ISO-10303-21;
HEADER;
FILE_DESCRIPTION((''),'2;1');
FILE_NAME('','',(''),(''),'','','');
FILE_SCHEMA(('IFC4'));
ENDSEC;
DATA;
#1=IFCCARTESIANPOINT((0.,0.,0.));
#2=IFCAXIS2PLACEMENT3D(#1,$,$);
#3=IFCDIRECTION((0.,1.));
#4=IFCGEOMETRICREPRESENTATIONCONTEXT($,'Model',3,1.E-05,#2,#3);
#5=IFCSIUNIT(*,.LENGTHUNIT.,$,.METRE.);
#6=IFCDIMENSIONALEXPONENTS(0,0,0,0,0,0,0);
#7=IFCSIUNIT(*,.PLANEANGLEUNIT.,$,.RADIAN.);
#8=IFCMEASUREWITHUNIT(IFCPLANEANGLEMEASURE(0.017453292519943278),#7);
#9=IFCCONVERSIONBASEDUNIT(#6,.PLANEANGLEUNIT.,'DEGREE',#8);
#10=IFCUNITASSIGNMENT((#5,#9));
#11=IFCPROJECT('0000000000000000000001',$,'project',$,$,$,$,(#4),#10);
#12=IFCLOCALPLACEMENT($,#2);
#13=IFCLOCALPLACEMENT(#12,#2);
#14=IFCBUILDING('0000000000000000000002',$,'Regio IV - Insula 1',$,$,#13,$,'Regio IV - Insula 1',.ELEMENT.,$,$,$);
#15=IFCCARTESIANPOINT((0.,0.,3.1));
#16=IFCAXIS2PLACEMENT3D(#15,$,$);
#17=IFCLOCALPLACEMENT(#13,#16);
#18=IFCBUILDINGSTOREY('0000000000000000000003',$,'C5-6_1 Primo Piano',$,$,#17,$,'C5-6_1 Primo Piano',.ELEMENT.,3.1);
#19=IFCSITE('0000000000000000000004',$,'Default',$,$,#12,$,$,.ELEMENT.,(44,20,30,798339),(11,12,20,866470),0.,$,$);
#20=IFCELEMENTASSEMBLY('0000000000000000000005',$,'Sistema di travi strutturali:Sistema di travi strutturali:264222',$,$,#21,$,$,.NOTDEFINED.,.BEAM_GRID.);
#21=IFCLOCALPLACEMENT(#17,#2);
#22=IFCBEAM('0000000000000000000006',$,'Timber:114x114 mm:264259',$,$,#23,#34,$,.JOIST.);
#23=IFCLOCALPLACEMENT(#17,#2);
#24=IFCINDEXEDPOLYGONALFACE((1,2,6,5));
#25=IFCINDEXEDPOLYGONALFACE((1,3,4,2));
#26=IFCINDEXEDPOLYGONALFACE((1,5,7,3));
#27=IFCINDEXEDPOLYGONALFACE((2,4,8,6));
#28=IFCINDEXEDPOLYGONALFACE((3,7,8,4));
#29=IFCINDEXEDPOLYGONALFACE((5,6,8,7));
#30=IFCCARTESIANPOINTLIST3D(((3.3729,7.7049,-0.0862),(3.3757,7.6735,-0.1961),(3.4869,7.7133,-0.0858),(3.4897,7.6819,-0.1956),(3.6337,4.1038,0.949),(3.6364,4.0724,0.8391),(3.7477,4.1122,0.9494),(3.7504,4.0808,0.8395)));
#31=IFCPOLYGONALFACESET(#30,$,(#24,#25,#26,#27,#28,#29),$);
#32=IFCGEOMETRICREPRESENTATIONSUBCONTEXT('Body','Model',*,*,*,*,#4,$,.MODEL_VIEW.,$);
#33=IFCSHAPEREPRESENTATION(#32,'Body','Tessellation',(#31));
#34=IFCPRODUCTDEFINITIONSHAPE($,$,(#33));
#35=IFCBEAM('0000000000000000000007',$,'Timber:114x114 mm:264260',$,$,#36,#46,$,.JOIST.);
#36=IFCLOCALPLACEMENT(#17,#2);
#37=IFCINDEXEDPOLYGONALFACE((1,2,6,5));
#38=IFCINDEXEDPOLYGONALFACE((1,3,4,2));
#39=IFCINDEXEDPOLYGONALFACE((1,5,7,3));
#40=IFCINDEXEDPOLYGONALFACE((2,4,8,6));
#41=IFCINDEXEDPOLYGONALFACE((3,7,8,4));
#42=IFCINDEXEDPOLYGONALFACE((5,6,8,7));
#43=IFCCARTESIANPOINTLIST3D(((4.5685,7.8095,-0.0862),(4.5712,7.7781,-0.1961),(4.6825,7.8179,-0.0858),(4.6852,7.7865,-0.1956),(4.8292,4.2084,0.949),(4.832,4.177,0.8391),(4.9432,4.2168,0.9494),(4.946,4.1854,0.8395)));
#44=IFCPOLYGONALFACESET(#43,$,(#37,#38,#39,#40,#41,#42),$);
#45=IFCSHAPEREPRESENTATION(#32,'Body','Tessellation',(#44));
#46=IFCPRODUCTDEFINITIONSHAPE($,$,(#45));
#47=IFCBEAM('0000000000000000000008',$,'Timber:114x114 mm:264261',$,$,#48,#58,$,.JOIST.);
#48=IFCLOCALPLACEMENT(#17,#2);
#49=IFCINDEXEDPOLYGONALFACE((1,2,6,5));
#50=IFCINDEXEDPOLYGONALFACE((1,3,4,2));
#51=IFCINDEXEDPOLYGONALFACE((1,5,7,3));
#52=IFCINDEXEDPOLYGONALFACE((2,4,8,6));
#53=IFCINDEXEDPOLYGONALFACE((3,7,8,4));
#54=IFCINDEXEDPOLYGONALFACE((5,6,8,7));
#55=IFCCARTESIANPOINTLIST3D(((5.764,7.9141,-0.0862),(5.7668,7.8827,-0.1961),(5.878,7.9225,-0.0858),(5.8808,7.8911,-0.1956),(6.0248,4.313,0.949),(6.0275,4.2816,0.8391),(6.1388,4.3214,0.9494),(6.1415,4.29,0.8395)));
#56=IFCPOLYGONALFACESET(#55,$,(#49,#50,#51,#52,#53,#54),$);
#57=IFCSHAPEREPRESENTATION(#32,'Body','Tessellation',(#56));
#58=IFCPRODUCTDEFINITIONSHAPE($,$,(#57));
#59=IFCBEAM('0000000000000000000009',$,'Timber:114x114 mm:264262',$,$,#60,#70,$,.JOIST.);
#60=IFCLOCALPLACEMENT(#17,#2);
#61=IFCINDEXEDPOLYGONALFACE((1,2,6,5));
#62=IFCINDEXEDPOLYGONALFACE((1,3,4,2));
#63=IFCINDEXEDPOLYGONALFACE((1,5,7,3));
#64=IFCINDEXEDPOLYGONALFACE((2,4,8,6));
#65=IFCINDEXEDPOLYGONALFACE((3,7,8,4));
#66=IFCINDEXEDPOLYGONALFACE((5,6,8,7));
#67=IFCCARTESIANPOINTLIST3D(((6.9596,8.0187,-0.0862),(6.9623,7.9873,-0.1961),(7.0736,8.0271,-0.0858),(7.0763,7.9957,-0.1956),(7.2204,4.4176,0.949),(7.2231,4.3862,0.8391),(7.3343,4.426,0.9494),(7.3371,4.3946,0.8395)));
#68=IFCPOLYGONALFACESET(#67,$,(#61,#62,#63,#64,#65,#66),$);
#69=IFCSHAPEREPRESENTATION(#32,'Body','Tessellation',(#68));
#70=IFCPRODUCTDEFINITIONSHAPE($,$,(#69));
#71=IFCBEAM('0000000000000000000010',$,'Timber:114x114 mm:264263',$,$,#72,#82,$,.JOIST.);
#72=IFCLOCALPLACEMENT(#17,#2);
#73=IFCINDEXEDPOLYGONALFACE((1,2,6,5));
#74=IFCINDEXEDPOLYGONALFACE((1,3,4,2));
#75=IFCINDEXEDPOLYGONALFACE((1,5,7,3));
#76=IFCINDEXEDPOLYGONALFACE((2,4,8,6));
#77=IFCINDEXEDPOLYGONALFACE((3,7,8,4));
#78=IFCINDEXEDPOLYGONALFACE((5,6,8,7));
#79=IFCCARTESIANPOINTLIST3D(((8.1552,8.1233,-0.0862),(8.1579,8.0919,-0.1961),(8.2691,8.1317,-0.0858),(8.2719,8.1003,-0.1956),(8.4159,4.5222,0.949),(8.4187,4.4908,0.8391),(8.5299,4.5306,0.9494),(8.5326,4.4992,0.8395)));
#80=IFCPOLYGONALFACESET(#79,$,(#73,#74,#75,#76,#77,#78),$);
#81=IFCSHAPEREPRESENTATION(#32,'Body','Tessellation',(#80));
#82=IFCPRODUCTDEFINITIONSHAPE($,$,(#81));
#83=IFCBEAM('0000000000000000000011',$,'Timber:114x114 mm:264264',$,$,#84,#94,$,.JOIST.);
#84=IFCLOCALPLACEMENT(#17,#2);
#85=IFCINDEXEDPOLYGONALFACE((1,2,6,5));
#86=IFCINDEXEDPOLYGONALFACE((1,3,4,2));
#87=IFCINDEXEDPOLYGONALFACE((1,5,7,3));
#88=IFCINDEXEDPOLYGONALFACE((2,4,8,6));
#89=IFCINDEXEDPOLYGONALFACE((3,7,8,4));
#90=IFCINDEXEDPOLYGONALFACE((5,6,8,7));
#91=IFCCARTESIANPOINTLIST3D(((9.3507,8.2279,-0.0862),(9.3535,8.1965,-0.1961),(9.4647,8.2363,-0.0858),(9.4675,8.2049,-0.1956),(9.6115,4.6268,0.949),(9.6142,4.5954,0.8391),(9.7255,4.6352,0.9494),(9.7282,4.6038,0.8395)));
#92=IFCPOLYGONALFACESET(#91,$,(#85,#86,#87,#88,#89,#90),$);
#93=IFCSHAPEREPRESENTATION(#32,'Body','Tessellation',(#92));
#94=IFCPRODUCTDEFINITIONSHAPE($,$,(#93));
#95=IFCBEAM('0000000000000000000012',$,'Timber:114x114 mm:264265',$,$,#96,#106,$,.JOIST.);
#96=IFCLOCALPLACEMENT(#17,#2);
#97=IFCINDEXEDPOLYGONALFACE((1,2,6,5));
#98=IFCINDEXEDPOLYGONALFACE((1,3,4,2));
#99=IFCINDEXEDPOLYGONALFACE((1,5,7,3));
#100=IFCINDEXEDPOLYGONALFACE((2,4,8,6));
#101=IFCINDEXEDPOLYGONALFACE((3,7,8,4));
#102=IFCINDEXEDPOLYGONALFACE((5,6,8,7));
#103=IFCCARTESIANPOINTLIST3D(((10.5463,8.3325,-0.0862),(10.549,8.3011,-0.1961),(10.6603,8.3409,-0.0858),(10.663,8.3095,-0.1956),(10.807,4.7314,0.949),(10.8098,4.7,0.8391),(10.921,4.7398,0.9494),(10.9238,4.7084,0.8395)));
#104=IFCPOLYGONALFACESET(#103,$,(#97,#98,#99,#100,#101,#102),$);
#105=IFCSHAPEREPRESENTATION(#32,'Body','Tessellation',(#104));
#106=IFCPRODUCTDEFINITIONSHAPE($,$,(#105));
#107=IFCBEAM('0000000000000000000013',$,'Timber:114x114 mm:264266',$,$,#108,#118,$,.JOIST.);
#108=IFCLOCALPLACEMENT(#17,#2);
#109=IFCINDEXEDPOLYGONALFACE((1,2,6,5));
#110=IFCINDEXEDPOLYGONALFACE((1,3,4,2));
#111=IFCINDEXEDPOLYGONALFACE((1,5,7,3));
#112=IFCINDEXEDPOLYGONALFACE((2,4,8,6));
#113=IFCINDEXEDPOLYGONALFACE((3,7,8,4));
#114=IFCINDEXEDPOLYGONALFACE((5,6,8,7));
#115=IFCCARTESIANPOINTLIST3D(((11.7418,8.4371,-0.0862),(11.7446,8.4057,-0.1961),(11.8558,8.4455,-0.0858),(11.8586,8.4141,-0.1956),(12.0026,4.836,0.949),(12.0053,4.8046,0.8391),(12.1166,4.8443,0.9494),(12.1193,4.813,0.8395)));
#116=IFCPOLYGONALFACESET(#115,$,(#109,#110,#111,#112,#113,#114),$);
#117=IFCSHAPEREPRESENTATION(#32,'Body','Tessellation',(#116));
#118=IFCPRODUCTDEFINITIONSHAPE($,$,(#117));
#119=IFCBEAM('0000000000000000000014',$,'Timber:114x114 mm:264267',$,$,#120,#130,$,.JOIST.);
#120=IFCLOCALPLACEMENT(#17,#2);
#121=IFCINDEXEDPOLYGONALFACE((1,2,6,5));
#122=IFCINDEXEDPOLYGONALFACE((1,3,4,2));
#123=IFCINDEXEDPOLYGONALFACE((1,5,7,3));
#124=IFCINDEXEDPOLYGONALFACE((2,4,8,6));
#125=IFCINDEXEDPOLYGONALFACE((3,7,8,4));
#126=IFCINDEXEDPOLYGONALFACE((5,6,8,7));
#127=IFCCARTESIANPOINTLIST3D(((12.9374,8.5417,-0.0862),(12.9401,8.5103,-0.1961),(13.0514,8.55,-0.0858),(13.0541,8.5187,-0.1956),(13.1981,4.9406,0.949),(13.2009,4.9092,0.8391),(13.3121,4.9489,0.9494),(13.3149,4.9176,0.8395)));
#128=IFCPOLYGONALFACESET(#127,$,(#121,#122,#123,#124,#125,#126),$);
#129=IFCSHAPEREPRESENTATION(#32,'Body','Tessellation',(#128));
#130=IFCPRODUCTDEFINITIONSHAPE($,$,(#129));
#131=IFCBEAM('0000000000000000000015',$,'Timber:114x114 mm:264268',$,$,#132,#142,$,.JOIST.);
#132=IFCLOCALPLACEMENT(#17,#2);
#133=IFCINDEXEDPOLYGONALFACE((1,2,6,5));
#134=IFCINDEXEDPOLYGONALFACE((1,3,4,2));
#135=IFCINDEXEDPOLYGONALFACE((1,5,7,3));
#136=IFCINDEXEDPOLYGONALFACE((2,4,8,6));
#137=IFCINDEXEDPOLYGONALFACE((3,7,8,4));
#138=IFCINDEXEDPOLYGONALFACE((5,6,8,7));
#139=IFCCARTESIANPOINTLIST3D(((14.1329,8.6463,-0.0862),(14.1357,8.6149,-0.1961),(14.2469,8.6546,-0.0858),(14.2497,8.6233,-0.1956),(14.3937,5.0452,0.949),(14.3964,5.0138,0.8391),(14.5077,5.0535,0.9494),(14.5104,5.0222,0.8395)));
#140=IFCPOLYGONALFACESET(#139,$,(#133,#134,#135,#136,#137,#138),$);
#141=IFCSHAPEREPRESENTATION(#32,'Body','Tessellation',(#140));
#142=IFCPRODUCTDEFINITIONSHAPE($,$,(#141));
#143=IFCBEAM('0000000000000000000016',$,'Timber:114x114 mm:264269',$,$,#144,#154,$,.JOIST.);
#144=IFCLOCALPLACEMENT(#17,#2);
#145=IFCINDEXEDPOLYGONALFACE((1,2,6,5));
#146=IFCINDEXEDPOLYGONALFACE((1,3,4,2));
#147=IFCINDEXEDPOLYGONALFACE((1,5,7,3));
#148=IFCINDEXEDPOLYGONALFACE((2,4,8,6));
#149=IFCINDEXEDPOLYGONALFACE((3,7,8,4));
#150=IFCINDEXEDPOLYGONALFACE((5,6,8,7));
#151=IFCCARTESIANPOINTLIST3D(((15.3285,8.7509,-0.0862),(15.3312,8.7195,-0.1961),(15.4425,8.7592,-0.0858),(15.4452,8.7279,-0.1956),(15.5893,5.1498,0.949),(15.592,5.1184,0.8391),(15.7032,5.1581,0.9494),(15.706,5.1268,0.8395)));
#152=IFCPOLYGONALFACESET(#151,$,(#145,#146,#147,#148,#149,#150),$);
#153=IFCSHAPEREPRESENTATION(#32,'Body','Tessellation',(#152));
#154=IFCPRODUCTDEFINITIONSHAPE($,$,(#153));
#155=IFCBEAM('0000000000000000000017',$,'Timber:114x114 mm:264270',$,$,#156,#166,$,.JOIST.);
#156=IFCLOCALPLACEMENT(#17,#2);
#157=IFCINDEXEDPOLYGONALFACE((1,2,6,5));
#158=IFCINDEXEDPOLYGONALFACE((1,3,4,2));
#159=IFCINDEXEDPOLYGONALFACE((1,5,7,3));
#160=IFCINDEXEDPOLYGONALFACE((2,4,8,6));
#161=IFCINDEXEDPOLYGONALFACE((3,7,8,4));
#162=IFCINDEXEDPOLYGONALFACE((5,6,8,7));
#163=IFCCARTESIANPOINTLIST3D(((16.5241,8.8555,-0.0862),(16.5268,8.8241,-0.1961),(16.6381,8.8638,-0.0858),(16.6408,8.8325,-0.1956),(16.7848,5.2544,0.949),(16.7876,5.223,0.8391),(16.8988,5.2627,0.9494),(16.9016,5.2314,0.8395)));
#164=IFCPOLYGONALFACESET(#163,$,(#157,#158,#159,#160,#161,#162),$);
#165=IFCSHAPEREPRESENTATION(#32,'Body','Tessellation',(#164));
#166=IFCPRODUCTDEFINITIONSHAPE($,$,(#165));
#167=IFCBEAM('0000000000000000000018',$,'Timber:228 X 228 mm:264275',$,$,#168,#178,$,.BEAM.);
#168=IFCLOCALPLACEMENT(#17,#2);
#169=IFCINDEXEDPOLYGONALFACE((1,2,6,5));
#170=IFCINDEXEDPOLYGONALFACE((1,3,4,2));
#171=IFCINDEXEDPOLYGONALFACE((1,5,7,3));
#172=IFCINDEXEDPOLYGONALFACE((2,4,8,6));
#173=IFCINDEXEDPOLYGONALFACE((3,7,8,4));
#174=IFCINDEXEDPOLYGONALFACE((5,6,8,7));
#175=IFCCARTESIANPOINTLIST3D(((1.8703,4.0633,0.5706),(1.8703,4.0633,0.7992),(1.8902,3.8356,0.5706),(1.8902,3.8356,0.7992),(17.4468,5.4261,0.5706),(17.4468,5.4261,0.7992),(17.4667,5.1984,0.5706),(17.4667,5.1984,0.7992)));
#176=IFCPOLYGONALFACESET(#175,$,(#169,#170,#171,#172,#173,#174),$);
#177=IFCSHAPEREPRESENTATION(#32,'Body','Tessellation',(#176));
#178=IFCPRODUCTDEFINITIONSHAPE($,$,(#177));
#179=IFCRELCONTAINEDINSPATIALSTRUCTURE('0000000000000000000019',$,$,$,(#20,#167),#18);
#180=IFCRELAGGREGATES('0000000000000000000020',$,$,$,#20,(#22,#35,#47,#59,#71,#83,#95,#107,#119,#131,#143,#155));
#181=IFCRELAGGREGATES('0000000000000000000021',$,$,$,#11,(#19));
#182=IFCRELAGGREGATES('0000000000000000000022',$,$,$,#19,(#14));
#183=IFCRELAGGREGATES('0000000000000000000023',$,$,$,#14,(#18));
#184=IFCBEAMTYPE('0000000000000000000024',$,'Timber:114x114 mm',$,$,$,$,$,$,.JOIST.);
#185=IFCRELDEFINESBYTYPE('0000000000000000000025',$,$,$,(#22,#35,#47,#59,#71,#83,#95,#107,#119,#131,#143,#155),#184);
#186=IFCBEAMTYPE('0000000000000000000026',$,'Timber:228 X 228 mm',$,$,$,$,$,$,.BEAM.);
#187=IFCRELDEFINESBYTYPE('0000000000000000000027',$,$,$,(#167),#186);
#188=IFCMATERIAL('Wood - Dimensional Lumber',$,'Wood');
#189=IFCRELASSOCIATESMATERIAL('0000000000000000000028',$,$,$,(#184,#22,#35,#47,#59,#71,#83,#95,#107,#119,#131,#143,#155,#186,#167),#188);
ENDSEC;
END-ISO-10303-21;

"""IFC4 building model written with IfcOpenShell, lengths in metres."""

from ifc_helpers import new_model, entity, si_unit, converted_unit, direction, frame, frame_2d, origin, origin_2d_with_axis, place, context, subcontext, project, spatial, rectangle, extrude, source, transform, mapped, material, material_profile, profile_set, profile_usage, type_object, type_shapes, element, aggregate, save


model = new_model("IFC4")

# Units and contexts
model_context = context("Model", 3, precision=1e-05, world=origin(), true_north=direction((0.0, 1.0)))
body_context = subcontext(model_context, "Body", "Model", "MODEL_VIEW")
ifc_project = project(units=[si_unit("LENGTHUNIT", "METRE"), converted_unit("PLANEANGLEUNIT", "DEGREE", entity("IfcPlaneAngleMeasure", 0.017453292519943278), si_unit("PLANEANGLEUNIT", "RADIAN"), dimensions=[0, 0, 0, 0, 0, 0, 0])], contexts=[model_context])

# Site, building, storey
site_placement = place(None, origin())
site = spatial("IfcSite", under=ifc_project, at=site_placement, Name="Default", CompositionType="ELEMENT", RefLatitude=(44, 20, 30, 798339), RefLongitude=(11, 12, 20, 866470), RefElevation=0.0)
building_placement = place(site_placement, origin())
building = spatial("IfcBuilding", under=site, at=building_placement, Name="Regio IV - Insula 1", LongName="Regio IV - Insula 1", CompositionType="ELEMENT")
storey_placement = place(building_placement, frame((0.0, 0.0, 3.1)))
storey = spatial("IfcBuildingStorey", under=building, at=storey_placement, Name="C5-6_1 Primo Piano", LongName="C5-6_1 Primo Piano", CompositionType="ELEMENT", Elevation=3.1)

# Element assembly, beams
ifc_material_1 = material(Name="Wood - Dimensional Lumber", Category="Wood")
ifc_material_profile_1 = material_profile(ifc_material_1, rectangle(XDim=5.294, YDim=0.1143, at=origin_2d_with_axis()), Name="114x114 mm")
ifc_profile_set_1 = profile_set([ifc_material_profile_1], Name="114x114 mm")
ifc_profile_usage_1 = profile_usage(ifc_profile_set_1, cardinal=8)
beam_type_1 = type_object("IfcBeamType", Name="Timber:114x114 mm", PredefinedType="JOIST", material=ifc_profile_set_1)
shared_shape_1 = source(origin(), body_context, "Body", "SweptSolid", [
    extrude(rectangle(XDim=3.756, YDim=0.1143, at=origin_2d_with_axis()), frame((0.0, 0.0, -0.0572), z_axis=(0.0, 0.0, 1.0), x_axis=(-1.0, 0.0, 0.0)), (0.0, 0.0, 1.0), 0.1143),
])
type_shapes(beam_type_1, [shared_shape_1])
assembly_1_placement = place(storey_placement, origin())
assembly_1 = element("IfcElementAssembly", 1, at=assembly_1_placement, inside=storey, Name="Sistema di travi strutturali:Sistema di travi strutturali:264222", AssemblyPlace="NOTDEFINED", PredefinedType="BEAM_GRID")
beam_1_placement = place(assembly_1_placement, frame((3.5617, 5.8928, 0.3767), z_axis=(-0.024023, 0.274588, 0.961262), x_axis=(0.069423, -0.95876, 0.275609)))
beam_1 = element("IfcBeam", 2, at=beam_1_placement, type_object=beam_type_1, material=ifc_profile_usage_1, Name="Timber:114x114 mm:264259", PredefinedType="JOIST", context=body_context, shape_type="MappedRepresentation", body=[
    mapped(shared_shape_1, transform((0.0, 0.0, 0.0), scale=1.0)),
])
beam_2_placement = place(assembly_1_placement, frame((4.7572, 5.9974, 0.3767), z_axis=(-0.024023, 0.274588, 0.961262), x_axis=(0.069423, -0.95876, 0.275609)))
beam_2 = element("IfcBeam", 3, at=beam_2_placement, type_object=beam_type_1, material=ifc_profile_usage_1, Name="Timber:114x114 mm:264260", PredefinedType="JOIST", context=body_context, shape_type="MappedRepresentation", body=[
    mapped(shared_shape_1, transform((0.0, 0.0, 0.0), scale=1.0)),
])
beam_3_placement = place(assembly_1_placement, frame((5.9528, 6.102, 0.3767), z_axis=(-0.024023, 0.274588, 0.961262), x_axis=(0.069423, -0.95876, 0.275609)))
beam_3 = element("IfcBeam", 4, at=beam_3_placement, type_object=beam_type_1, material=ifc_profile_usage_1, Name="Timber:114x114 mm:264261", PredefinedType="JOIST", context=body_context, shape_type="MappedRepresentation", body=[
    mapped(shared_shape_1, transform((0.0, 0.0, 0.0), scale=1.0)),
])
beam_4_placement = place(assembly_1_placement, frame((7.1483, 6.2066, 0.3767), z_axis=(-0.024023, 0.274588, 0.961262), x_axis=(0.069423, -0.95876, 0.275609)))
beam_4 = element("IfcBeam", 5, at=beam_4_placement, type_object=beam_type_1, material=ifc_profile_usage_1, Name="Timber:114x114 mm:264262", PredefinedType="JOIST", context=body_context, shape_type="MappedRepresentation", body=[
    mapped(shared_shape_1, transform((0.0, 0.0, 0.0), scale=1.0)),
])
beam_5_placement = place(assembly_1_placement, frame((8.3439, 6.3112, 0.3767), z_axis=(-0.024023, 0.274588, 0.961262), x_axis=(0.069423, -0.95876, 0.275609)))
beam_5 = element("IfcBeam", 6, at=beam_5_placement, type_object=beam_type_1, material=ifc_profile_usage_1, Name="Timber:114x114 mm:264263", PredefinedType="JOIST", context=body_context, shape_type="MappedRepresentation", body=[
    mapped(shared_shape_1, transform((0.0, 0.0, 0.0), scale=1.0)),
])
beam_6_placement = place(assembly_1_placement, frame((9.5395, 6.4158, 0.3767), z_axis=(-0.024023, 0.274588, 0.961262), x_axis=(0.069423, -0.95876, 0.275609)))
beam_6 = element("IfcBeam", 7, at=beam_6_placement, type_object=beam_type_1, material=ifc_profile_usage_1, Name="Timber:114x114 mm:264264", PredefinedType="JOIST", context=body_context, shape_type="MappedRepresentation", body=[
    mapped(shared_shape_1, transform((0.0, 0.0, 0.0), scale=1.0)),
])
beam_7_placement = place(assembly_1_placement, frame((10.735, 6.5204, 0.3767), z_axis=(-0.024023, 0.274588, 0.961262), x_axis=(0.069423, -0.95876, 0.275609)))
beam_7 = element("IfcBeam", 8, at=beam_7_placement, type_object=beam_type_1, material=ifc_profile_usage_1, Name="Timber:114x114 mm:264265", PredefinedType="JOIST", context=body_context, shape_type="MappedRepresentation", body=[
    mapped(shared_shape_1, transform((0.0, 0.0, 0.0), scale=1.0)),
])
beam_8_placement = place(assembly_1_placement, frame((11.9306, 6.625, 0.3767), z_axis=(-0.024023, 0.274588, 0.961262), x_axis=(0.069423, -0.95876, 0.275609)))
beam_8 = element("IfcBeam", 9, at=beam_8_placement, type_object=beam_type_1, material=ifc_profile_usage_1, Name="Timber:114x114 mm:264266", PredefinedType="JOIST", context=body_context, shape_type="MappedRepresentation", body=[
    mapped(shared_shape_1, transform((0.0, 0.0, 0.0), scale=1.0)),
])
beam_9_placement = place(assembly_1_placement, frame((13.1261, 6.7296, 0.3767), z_axis=(-0.024023, 0.274588, 0.961262), x_axis=(0.069423, -0.95876, 0.275609)))
beam_9 = element("IfcBeam", 10, at=beam_9_placement, type_object=beam_type_1, material=ifc_profile_usage_1, Name="Timber:114x114 mm:264267", PredefinedType="JOIST", context=body_context, shape_type="MappedRepresentation", body=[
    mapped(shared_shape_1, transform((0.0, 0.0, 0.0), scale=1.0)),
])
beam_10_placement = place(assembly_1_placement, frame((14.3217, 6.8342, 0.3767), z_axis=(-0.024023, 0.274588, 0.961262), x_axis=(0.069423, -0.95876, 0.275609)))
beam_10 = element("IfcBeam", 11, at=beam_10_placement, type_object=beam_type_1, material=ifc_profile_usage_1, Name="Timber:114x114 mm:264268", PredefinedType="JOIST", context=body_context, shape_type="MappedRepresentation", body=[
    mapped(shared_shape_1, transform((0.0, 0.0, 0.0), scale=1.0)),
])
beam_11_placement = place(assembly_1_placement, frame((15.5172, 6.9388, 0.3767), z_axis=(-0.024023, 0.274588, 0.961262), x_axis=(0.069423, -0.95876, 0.275609)))
beam_11 = element("IfcBeam", 12, at=beam_11_placement, type_object=beam_type_1, material=ifc_profile_usage_1, Name="Timber:114x114 mm:264269", PredefinedType="JOIST", context=body_context, shape_type="MappedRepresentation", body=[
    mapped(shared_shape_1, transform((0.0, 0.0, 0.0), scale=1.0)),
])
beam_12_placement = place(assembly_1_placement, frame((16.7128, 7.0434, 0.3767), z_axis=(-0.024023, 0.274588, 0.961262), x_axis=(0.069423, -0.95876, 0.275609)))
beam_12 = element("IfcBeam", 13, at=beam_12_placement, type_object=beam_type_1, material=ifc_profile_usage_1, Name="Timber:114x114 mm:264270", PredefinedType="JOIST", context=body_context, shape_type="MappedRepresentation", body=[
    mapped(shared_shape_1, transform((0.0, 0.0, 0.0), scale=1.0)),
])
aggregate(assembly_1, [beam_1, beam_2, beam_3, beam_4, beam_5, beam_6, beam_7, beam_8, beam_9, beam_10, beam_11, beam_12])

# Beam
ifc_material_profile_2 = material_profile(ifc_material_1, rectangle(XDim=8.091, YDim=0.2286, at=frame_2d((0.0, 0.0), x_axis=(1.0, 0.0))), Name="228 X 228 mm")
ifc_profile_set_2 = profile_set([ifc_material_profile_2], Name="228 X 228 mm")
ifc_profile_usage_2 = profile_usage(ifc_profile_set_2, cardinal=1)
beam_type_2 = type_object("IfcBeamType", Name="Timber:228 X 228 mm", PredefinedType="BEAM", material=ifc_profile_set_2)
shared_shape_2 = source(origin(), body_context, "Body", "SweptSolid", [
    extrude(rectangle(XDim=15.636, YDim=0.2286, at=frame_2d((0.0, 0.0), x_axis=(1.0, 0.0))), frame((0.0, 0.0, -0.1143), z_axis=(0.0, 0.0, 1.0), x_axis=(-1.0, 0.0, 0.0)), (0.0, 0.0, 1.0), 0.2286),
])
type_shapes(beam_type_2, [shared_shape_2])
beam_13_placement = place(storey_placement, frame((9.6685, 4.6309, 0.6849), z_axis=(0.0, 0.0, 1.0), x_axis=(-0.996195, -0.087156, 0.0)))
element("IfcBeam", 14, at=beam_13_placement, inside=storey, type_object=beam_type_2, material=ifc_profile_usage_2, Name="Timber:228 X 228 mm:264275", PredefinedType="BEAM", context=body_context, shape_type="MappedRepresentation", body=[
    mapped(shared_shape_2, transform((0.0, 0.0, 0.0), scale=1.0)),
])

save(model, "model.ifc")
